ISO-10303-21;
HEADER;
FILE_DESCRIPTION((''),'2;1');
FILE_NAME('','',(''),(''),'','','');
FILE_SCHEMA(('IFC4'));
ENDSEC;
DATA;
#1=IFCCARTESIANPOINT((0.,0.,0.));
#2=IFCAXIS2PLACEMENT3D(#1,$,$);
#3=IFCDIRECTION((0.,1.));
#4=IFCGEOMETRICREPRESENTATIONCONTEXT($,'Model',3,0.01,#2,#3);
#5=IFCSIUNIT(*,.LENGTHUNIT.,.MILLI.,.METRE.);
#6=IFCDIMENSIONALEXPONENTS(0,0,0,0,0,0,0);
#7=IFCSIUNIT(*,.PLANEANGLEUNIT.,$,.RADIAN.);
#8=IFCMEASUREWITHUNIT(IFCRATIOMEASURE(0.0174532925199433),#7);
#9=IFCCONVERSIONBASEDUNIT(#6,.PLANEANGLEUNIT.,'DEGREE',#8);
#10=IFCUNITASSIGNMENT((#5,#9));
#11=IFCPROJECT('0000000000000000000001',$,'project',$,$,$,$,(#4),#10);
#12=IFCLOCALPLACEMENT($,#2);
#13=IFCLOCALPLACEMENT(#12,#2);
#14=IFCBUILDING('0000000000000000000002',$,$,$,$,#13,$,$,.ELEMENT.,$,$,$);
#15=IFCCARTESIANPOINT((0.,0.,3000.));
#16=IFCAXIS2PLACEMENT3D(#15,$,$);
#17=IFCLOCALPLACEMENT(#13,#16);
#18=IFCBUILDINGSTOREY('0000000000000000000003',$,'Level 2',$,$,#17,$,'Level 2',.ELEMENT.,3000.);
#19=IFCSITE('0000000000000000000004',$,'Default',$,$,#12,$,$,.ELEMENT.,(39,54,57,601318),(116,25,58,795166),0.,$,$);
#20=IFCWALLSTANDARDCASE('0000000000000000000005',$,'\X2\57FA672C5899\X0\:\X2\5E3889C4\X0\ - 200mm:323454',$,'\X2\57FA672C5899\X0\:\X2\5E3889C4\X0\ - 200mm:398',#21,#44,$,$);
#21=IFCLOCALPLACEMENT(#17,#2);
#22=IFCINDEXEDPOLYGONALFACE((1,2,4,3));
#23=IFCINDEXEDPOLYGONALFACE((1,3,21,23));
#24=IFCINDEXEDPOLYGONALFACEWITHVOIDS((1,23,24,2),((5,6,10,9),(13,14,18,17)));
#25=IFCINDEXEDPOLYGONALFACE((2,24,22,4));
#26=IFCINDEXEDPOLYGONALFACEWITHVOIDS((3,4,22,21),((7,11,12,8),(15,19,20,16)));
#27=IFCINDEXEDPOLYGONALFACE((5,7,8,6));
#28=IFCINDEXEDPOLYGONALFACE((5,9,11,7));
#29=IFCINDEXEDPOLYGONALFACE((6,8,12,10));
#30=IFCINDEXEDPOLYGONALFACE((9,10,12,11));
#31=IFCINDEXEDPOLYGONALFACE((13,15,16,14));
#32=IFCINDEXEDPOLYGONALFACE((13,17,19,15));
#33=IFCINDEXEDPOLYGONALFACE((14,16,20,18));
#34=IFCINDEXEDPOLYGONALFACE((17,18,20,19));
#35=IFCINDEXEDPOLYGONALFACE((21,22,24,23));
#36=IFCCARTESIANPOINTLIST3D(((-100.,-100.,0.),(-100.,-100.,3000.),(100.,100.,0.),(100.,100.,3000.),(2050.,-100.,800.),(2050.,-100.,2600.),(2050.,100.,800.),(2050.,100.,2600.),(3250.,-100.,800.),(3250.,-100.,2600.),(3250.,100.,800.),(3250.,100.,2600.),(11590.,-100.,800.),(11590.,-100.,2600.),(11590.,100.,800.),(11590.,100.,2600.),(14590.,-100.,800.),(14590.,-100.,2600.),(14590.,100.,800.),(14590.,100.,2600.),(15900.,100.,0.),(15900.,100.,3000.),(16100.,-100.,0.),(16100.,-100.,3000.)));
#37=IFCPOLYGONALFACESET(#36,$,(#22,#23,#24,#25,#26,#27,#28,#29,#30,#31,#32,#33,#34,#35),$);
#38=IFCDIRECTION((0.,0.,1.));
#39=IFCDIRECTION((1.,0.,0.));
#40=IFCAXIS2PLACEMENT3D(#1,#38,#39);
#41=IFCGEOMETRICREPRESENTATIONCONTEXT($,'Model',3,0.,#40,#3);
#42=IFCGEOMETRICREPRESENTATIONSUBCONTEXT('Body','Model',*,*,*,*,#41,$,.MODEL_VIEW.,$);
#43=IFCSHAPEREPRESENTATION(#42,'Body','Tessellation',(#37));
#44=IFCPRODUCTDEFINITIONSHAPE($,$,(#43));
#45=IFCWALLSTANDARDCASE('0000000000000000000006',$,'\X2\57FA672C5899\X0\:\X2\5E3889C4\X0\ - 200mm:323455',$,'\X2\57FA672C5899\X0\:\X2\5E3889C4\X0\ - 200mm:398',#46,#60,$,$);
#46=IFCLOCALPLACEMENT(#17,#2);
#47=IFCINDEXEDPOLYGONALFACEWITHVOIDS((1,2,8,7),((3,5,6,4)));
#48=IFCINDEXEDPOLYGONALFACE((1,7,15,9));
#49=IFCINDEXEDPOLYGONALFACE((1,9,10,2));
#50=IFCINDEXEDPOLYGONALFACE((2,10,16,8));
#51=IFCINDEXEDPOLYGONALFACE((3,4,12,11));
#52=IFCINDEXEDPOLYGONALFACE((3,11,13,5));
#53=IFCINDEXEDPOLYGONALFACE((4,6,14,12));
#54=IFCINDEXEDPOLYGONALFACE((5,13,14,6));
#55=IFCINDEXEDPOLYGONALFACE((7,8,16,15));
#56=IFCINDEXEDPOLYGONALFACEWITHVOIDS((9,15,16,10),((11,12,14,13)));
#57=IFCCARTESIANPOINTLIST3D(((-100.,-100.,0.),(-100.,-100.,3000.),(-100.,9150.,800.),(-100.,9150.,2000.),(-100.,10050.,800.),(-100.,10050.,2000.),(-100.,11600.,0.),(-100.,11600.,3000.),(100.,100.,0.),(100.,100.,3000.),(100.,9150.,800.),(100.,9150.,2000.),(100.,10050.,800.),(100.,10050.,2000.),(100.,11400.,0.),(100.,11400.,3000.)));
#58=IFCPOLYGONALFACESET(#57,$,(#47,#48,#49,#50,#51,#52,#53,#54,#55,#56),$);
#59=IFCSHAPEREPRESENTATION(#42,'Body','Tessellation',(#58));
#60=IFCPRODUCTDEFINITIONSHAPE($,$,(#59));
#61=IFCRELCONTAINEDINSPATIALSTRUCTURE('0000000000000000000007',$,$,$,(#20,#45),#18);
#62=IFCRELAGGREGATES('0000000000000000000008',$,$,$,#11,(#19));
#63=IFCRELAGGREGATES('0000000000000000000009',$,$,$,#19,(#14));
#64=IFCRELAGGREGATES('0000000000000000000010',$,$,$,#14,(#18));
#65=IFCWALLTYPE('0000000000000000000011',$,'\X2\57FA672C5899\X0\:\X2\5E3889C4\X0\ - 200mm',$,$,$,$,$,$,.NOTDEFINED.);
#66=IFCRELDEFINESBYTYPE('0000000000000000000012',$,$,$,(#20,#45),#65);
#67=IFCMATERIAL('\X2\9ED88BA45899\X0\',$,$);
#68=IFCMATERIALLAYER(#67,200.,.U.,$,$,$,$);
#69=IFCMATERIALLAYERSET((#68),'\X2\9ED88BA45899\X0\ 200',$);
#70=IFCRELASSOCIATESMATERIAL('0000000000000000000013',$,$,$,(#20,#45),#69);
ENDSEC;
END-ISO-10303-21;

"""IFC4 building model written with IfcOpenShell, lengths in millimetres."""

from ifc_helpers import new_model, entity, si_unit, converted_unit, direction, frame, origin, origin_with_axes, place, context, subcontext, project, spatial, polyline, outline, extrude, material, layer, layer_set, layer_usage, type_object, element, save


model = new_model("IFC4")

# Units and contexts
model_context_1 = context("Model", 3, precision=0.01, world=origin(), true_north=direction((0.0, 1.0)))
model_context_2 = context("Model", 3, precision=0.0, world=origin_with_axes(), true_north=direction((0.0, 1.0)))
body_context_1 = subcontext(model_context_2, "Body", "Model", "MODEL_VIEW")
ifc_project = project(units=[si_unit("LENGTHUNIT", "METRE", prefix="MILLI"), converted_unit("PLANEANGLEUNIT", "DEGREE", entity("IfcRatioMeasure", 0.0174532925199433), si_unit("PLANEANGLEUNIT", "RADIAN"), dimensions=[0, 0, 0, 0, 0, 0, 0])], contexts=[model_context_1])

# Site, building, storey
site_placement = place(None, origin())
site = spatial("IfcSite", under=ifc_project, at=site_placement, Name="Default", CompositionType="ELEMENT", RefLatitude=(39, 54, 57, 601318), RefLongitude=(116, 25, 58, 795166), RefElevation=0.0)
building_placement = place(site_placement, origin())
building = spatial("IfcBuilding", under=site, at=building_placement, CompositionType="ELEMENT")
storey_placement = place(building_placement, frame((0.0, 0.0, 3000.0)))
storey = spatial("IfcBuildingStorey", under=building, at=storey_placement, Name="Level 2", LongName="Level 2", CompositionType="ELEMENT", Elevation=3000.0)

# Shared definitions
placement_1 = place(None, origin_with_axes())
placement_2 = place(placement_1, origin_with_axes())
placement_3 = place(placement_2, frame((0.0, 0.0, 3000.0), z_axis=(0.0, 0.0, 1.0), x_axis=(1.0, 0.0, 0.0)))

# Shared definitions
ifc_material_1 = material(Name="默认墙")
ifc_layer_1 = layer(ifc_material_1, 200.0, ventilated="UNKNOWN")
ifc_layer_set_1 = layer_set([ifc_layer_1], Name="默认墙 200")
wall_type = type_object("IfcWallType", Name="基本墙:常规 - 200mm", PredefinedType="NOTDEFINED")

# Wall, openings
ifc_layer_usage_1 = layer_usage(ifc_layer_set_1, "AXIS2", "POSITIVE", -100.0)
wall_1_placement = place(placement_3, frame((16000.0, 0.0, 0.0), z_axis=(0.0, 0.0, 1.0), x_axis=(-1.0, 0.0, 0.0)))
wall_1 = element("IfcWallStandardCase", 1, at=wall_1_placement, inside=storey, type_object=wall_type, material=ifc_layer_usage_1, Name="基本墙:常规 - 200mm:323454", ObjectType="基本墙:常规 - 200mm:398", context=body_context_1, shape_type="SweptSolid", body=[
    extrude(outline(polyline([(100.0, -100.0), (15900.0, -100.0), (16100.0, 100.0), (-100.0, 100.0), (100.0, -100.0)])), origin_with_axes(), (0.0, 0.0, 1.0), 3000.0),
])
opening_1_placement = place(wall_1_placement, frame((13350.0, 0.0, 800.0), z_axis=(0.0, 0.0, 1.0), x_axis=(1.0, 0.0, 0.0)))
element("IfcOpeningElement", 2, at=opening_1_placement, cuts=wall_1, context=body_context_1, shape_type="SweptSolid", body=[
    extrude(outline(polyline([(-600.0, 0.0), (-600.0, -1800.0), (600.0, -1800.0), (600.0, 0.0), (-600.0, 0.0)])), frame((0.0, -100.0, 0.0), z_axis=(0.0, 1.0, 0.0), x_axis=(1.0, 0.0, 0.0)), (0.0, 0.0, 1.0), 200.0),
])
opening_2_placement = place(wall_1_placement, frame((2910.0, 0.0, 800.0), z_axis=(0.0, 0.0, 1.0), x_axis=(1.0, 0.0, 0.0)))
element("IfcOpeningElement", 3, at=opening_2_placement, cuts=wall_1, context=body_context_1, shape_type="SweptSolid", body=[
    extrude(outline(polyline([(-1500.0, 0.0), (-1500.0, -1800.0), (1500.0, -1800.0), (1500.0, 0.0), (-1500.0, 0.0)])), frame((0.0, -100.0, 0.0), z_axis=(0.0, 1.0, 0.0), x_axis=(1.0, 0.0, 0.0)), (0.0, 0.0, 1.0), 200.0),
])

# Wall, opening
ifc_layer_usage_2 = layer_usage(ifc_layer_set_1, "AXIS2", "POSITIVE", -100.0)
wall_2_placement = place(placement_3, frame((0.0, 0.0, 0.0), z_axis=(0.0, 0.0, 1.0), x_axis=(0.0, 1.0, 0.0)))
wall_2 = element("IfcWallStandardCase", 4, at=wall_2_placement, inside=storey, type_object=wall_type, material=ifc_layer_usage_2, Name="基本墙:常规 - 200mm:323455", ObjectType="基本墙:常规 - 200mm:398", context=body_context_1, shape_type="SweptSolid", body=[
    extrude(outline(polyline([(100.0, -100.0), (11400.0, -100.0), (11600.0, 100.0), (-100.0, 100.0), (100.0, -100.0)])), origin_with_axes(), (0.0, 0.0, 1.0), 3000.0),
])
opening_3_placement = place(wall_2_placement, frame((9600.0, 0.0, 800.0), z_axis=(0.0, 0.0, 1.0), x_axis=(1.0, 0.0, 0.0)))
element("IfcOpeningElement", 5, at=opening_3_placement, cuts=wall_2, context=body_context_1, shape_type="SweptSolid", body=[
    extrude(outline(polyline([(450.0, -1200.0), (450.0, 0.0), (-450.0, 0.0), (-450.0, -1200.0), (450.0, -1200.0)])), frame((0.0, 100.0, 0.0), z_axis=(0.0, -1.0, 0.0), x_axis=(-1.0, 0.0, 0.0)), (0.0, 0.0, 1.0), 200.0),
])

save(model, "model.ifc")
